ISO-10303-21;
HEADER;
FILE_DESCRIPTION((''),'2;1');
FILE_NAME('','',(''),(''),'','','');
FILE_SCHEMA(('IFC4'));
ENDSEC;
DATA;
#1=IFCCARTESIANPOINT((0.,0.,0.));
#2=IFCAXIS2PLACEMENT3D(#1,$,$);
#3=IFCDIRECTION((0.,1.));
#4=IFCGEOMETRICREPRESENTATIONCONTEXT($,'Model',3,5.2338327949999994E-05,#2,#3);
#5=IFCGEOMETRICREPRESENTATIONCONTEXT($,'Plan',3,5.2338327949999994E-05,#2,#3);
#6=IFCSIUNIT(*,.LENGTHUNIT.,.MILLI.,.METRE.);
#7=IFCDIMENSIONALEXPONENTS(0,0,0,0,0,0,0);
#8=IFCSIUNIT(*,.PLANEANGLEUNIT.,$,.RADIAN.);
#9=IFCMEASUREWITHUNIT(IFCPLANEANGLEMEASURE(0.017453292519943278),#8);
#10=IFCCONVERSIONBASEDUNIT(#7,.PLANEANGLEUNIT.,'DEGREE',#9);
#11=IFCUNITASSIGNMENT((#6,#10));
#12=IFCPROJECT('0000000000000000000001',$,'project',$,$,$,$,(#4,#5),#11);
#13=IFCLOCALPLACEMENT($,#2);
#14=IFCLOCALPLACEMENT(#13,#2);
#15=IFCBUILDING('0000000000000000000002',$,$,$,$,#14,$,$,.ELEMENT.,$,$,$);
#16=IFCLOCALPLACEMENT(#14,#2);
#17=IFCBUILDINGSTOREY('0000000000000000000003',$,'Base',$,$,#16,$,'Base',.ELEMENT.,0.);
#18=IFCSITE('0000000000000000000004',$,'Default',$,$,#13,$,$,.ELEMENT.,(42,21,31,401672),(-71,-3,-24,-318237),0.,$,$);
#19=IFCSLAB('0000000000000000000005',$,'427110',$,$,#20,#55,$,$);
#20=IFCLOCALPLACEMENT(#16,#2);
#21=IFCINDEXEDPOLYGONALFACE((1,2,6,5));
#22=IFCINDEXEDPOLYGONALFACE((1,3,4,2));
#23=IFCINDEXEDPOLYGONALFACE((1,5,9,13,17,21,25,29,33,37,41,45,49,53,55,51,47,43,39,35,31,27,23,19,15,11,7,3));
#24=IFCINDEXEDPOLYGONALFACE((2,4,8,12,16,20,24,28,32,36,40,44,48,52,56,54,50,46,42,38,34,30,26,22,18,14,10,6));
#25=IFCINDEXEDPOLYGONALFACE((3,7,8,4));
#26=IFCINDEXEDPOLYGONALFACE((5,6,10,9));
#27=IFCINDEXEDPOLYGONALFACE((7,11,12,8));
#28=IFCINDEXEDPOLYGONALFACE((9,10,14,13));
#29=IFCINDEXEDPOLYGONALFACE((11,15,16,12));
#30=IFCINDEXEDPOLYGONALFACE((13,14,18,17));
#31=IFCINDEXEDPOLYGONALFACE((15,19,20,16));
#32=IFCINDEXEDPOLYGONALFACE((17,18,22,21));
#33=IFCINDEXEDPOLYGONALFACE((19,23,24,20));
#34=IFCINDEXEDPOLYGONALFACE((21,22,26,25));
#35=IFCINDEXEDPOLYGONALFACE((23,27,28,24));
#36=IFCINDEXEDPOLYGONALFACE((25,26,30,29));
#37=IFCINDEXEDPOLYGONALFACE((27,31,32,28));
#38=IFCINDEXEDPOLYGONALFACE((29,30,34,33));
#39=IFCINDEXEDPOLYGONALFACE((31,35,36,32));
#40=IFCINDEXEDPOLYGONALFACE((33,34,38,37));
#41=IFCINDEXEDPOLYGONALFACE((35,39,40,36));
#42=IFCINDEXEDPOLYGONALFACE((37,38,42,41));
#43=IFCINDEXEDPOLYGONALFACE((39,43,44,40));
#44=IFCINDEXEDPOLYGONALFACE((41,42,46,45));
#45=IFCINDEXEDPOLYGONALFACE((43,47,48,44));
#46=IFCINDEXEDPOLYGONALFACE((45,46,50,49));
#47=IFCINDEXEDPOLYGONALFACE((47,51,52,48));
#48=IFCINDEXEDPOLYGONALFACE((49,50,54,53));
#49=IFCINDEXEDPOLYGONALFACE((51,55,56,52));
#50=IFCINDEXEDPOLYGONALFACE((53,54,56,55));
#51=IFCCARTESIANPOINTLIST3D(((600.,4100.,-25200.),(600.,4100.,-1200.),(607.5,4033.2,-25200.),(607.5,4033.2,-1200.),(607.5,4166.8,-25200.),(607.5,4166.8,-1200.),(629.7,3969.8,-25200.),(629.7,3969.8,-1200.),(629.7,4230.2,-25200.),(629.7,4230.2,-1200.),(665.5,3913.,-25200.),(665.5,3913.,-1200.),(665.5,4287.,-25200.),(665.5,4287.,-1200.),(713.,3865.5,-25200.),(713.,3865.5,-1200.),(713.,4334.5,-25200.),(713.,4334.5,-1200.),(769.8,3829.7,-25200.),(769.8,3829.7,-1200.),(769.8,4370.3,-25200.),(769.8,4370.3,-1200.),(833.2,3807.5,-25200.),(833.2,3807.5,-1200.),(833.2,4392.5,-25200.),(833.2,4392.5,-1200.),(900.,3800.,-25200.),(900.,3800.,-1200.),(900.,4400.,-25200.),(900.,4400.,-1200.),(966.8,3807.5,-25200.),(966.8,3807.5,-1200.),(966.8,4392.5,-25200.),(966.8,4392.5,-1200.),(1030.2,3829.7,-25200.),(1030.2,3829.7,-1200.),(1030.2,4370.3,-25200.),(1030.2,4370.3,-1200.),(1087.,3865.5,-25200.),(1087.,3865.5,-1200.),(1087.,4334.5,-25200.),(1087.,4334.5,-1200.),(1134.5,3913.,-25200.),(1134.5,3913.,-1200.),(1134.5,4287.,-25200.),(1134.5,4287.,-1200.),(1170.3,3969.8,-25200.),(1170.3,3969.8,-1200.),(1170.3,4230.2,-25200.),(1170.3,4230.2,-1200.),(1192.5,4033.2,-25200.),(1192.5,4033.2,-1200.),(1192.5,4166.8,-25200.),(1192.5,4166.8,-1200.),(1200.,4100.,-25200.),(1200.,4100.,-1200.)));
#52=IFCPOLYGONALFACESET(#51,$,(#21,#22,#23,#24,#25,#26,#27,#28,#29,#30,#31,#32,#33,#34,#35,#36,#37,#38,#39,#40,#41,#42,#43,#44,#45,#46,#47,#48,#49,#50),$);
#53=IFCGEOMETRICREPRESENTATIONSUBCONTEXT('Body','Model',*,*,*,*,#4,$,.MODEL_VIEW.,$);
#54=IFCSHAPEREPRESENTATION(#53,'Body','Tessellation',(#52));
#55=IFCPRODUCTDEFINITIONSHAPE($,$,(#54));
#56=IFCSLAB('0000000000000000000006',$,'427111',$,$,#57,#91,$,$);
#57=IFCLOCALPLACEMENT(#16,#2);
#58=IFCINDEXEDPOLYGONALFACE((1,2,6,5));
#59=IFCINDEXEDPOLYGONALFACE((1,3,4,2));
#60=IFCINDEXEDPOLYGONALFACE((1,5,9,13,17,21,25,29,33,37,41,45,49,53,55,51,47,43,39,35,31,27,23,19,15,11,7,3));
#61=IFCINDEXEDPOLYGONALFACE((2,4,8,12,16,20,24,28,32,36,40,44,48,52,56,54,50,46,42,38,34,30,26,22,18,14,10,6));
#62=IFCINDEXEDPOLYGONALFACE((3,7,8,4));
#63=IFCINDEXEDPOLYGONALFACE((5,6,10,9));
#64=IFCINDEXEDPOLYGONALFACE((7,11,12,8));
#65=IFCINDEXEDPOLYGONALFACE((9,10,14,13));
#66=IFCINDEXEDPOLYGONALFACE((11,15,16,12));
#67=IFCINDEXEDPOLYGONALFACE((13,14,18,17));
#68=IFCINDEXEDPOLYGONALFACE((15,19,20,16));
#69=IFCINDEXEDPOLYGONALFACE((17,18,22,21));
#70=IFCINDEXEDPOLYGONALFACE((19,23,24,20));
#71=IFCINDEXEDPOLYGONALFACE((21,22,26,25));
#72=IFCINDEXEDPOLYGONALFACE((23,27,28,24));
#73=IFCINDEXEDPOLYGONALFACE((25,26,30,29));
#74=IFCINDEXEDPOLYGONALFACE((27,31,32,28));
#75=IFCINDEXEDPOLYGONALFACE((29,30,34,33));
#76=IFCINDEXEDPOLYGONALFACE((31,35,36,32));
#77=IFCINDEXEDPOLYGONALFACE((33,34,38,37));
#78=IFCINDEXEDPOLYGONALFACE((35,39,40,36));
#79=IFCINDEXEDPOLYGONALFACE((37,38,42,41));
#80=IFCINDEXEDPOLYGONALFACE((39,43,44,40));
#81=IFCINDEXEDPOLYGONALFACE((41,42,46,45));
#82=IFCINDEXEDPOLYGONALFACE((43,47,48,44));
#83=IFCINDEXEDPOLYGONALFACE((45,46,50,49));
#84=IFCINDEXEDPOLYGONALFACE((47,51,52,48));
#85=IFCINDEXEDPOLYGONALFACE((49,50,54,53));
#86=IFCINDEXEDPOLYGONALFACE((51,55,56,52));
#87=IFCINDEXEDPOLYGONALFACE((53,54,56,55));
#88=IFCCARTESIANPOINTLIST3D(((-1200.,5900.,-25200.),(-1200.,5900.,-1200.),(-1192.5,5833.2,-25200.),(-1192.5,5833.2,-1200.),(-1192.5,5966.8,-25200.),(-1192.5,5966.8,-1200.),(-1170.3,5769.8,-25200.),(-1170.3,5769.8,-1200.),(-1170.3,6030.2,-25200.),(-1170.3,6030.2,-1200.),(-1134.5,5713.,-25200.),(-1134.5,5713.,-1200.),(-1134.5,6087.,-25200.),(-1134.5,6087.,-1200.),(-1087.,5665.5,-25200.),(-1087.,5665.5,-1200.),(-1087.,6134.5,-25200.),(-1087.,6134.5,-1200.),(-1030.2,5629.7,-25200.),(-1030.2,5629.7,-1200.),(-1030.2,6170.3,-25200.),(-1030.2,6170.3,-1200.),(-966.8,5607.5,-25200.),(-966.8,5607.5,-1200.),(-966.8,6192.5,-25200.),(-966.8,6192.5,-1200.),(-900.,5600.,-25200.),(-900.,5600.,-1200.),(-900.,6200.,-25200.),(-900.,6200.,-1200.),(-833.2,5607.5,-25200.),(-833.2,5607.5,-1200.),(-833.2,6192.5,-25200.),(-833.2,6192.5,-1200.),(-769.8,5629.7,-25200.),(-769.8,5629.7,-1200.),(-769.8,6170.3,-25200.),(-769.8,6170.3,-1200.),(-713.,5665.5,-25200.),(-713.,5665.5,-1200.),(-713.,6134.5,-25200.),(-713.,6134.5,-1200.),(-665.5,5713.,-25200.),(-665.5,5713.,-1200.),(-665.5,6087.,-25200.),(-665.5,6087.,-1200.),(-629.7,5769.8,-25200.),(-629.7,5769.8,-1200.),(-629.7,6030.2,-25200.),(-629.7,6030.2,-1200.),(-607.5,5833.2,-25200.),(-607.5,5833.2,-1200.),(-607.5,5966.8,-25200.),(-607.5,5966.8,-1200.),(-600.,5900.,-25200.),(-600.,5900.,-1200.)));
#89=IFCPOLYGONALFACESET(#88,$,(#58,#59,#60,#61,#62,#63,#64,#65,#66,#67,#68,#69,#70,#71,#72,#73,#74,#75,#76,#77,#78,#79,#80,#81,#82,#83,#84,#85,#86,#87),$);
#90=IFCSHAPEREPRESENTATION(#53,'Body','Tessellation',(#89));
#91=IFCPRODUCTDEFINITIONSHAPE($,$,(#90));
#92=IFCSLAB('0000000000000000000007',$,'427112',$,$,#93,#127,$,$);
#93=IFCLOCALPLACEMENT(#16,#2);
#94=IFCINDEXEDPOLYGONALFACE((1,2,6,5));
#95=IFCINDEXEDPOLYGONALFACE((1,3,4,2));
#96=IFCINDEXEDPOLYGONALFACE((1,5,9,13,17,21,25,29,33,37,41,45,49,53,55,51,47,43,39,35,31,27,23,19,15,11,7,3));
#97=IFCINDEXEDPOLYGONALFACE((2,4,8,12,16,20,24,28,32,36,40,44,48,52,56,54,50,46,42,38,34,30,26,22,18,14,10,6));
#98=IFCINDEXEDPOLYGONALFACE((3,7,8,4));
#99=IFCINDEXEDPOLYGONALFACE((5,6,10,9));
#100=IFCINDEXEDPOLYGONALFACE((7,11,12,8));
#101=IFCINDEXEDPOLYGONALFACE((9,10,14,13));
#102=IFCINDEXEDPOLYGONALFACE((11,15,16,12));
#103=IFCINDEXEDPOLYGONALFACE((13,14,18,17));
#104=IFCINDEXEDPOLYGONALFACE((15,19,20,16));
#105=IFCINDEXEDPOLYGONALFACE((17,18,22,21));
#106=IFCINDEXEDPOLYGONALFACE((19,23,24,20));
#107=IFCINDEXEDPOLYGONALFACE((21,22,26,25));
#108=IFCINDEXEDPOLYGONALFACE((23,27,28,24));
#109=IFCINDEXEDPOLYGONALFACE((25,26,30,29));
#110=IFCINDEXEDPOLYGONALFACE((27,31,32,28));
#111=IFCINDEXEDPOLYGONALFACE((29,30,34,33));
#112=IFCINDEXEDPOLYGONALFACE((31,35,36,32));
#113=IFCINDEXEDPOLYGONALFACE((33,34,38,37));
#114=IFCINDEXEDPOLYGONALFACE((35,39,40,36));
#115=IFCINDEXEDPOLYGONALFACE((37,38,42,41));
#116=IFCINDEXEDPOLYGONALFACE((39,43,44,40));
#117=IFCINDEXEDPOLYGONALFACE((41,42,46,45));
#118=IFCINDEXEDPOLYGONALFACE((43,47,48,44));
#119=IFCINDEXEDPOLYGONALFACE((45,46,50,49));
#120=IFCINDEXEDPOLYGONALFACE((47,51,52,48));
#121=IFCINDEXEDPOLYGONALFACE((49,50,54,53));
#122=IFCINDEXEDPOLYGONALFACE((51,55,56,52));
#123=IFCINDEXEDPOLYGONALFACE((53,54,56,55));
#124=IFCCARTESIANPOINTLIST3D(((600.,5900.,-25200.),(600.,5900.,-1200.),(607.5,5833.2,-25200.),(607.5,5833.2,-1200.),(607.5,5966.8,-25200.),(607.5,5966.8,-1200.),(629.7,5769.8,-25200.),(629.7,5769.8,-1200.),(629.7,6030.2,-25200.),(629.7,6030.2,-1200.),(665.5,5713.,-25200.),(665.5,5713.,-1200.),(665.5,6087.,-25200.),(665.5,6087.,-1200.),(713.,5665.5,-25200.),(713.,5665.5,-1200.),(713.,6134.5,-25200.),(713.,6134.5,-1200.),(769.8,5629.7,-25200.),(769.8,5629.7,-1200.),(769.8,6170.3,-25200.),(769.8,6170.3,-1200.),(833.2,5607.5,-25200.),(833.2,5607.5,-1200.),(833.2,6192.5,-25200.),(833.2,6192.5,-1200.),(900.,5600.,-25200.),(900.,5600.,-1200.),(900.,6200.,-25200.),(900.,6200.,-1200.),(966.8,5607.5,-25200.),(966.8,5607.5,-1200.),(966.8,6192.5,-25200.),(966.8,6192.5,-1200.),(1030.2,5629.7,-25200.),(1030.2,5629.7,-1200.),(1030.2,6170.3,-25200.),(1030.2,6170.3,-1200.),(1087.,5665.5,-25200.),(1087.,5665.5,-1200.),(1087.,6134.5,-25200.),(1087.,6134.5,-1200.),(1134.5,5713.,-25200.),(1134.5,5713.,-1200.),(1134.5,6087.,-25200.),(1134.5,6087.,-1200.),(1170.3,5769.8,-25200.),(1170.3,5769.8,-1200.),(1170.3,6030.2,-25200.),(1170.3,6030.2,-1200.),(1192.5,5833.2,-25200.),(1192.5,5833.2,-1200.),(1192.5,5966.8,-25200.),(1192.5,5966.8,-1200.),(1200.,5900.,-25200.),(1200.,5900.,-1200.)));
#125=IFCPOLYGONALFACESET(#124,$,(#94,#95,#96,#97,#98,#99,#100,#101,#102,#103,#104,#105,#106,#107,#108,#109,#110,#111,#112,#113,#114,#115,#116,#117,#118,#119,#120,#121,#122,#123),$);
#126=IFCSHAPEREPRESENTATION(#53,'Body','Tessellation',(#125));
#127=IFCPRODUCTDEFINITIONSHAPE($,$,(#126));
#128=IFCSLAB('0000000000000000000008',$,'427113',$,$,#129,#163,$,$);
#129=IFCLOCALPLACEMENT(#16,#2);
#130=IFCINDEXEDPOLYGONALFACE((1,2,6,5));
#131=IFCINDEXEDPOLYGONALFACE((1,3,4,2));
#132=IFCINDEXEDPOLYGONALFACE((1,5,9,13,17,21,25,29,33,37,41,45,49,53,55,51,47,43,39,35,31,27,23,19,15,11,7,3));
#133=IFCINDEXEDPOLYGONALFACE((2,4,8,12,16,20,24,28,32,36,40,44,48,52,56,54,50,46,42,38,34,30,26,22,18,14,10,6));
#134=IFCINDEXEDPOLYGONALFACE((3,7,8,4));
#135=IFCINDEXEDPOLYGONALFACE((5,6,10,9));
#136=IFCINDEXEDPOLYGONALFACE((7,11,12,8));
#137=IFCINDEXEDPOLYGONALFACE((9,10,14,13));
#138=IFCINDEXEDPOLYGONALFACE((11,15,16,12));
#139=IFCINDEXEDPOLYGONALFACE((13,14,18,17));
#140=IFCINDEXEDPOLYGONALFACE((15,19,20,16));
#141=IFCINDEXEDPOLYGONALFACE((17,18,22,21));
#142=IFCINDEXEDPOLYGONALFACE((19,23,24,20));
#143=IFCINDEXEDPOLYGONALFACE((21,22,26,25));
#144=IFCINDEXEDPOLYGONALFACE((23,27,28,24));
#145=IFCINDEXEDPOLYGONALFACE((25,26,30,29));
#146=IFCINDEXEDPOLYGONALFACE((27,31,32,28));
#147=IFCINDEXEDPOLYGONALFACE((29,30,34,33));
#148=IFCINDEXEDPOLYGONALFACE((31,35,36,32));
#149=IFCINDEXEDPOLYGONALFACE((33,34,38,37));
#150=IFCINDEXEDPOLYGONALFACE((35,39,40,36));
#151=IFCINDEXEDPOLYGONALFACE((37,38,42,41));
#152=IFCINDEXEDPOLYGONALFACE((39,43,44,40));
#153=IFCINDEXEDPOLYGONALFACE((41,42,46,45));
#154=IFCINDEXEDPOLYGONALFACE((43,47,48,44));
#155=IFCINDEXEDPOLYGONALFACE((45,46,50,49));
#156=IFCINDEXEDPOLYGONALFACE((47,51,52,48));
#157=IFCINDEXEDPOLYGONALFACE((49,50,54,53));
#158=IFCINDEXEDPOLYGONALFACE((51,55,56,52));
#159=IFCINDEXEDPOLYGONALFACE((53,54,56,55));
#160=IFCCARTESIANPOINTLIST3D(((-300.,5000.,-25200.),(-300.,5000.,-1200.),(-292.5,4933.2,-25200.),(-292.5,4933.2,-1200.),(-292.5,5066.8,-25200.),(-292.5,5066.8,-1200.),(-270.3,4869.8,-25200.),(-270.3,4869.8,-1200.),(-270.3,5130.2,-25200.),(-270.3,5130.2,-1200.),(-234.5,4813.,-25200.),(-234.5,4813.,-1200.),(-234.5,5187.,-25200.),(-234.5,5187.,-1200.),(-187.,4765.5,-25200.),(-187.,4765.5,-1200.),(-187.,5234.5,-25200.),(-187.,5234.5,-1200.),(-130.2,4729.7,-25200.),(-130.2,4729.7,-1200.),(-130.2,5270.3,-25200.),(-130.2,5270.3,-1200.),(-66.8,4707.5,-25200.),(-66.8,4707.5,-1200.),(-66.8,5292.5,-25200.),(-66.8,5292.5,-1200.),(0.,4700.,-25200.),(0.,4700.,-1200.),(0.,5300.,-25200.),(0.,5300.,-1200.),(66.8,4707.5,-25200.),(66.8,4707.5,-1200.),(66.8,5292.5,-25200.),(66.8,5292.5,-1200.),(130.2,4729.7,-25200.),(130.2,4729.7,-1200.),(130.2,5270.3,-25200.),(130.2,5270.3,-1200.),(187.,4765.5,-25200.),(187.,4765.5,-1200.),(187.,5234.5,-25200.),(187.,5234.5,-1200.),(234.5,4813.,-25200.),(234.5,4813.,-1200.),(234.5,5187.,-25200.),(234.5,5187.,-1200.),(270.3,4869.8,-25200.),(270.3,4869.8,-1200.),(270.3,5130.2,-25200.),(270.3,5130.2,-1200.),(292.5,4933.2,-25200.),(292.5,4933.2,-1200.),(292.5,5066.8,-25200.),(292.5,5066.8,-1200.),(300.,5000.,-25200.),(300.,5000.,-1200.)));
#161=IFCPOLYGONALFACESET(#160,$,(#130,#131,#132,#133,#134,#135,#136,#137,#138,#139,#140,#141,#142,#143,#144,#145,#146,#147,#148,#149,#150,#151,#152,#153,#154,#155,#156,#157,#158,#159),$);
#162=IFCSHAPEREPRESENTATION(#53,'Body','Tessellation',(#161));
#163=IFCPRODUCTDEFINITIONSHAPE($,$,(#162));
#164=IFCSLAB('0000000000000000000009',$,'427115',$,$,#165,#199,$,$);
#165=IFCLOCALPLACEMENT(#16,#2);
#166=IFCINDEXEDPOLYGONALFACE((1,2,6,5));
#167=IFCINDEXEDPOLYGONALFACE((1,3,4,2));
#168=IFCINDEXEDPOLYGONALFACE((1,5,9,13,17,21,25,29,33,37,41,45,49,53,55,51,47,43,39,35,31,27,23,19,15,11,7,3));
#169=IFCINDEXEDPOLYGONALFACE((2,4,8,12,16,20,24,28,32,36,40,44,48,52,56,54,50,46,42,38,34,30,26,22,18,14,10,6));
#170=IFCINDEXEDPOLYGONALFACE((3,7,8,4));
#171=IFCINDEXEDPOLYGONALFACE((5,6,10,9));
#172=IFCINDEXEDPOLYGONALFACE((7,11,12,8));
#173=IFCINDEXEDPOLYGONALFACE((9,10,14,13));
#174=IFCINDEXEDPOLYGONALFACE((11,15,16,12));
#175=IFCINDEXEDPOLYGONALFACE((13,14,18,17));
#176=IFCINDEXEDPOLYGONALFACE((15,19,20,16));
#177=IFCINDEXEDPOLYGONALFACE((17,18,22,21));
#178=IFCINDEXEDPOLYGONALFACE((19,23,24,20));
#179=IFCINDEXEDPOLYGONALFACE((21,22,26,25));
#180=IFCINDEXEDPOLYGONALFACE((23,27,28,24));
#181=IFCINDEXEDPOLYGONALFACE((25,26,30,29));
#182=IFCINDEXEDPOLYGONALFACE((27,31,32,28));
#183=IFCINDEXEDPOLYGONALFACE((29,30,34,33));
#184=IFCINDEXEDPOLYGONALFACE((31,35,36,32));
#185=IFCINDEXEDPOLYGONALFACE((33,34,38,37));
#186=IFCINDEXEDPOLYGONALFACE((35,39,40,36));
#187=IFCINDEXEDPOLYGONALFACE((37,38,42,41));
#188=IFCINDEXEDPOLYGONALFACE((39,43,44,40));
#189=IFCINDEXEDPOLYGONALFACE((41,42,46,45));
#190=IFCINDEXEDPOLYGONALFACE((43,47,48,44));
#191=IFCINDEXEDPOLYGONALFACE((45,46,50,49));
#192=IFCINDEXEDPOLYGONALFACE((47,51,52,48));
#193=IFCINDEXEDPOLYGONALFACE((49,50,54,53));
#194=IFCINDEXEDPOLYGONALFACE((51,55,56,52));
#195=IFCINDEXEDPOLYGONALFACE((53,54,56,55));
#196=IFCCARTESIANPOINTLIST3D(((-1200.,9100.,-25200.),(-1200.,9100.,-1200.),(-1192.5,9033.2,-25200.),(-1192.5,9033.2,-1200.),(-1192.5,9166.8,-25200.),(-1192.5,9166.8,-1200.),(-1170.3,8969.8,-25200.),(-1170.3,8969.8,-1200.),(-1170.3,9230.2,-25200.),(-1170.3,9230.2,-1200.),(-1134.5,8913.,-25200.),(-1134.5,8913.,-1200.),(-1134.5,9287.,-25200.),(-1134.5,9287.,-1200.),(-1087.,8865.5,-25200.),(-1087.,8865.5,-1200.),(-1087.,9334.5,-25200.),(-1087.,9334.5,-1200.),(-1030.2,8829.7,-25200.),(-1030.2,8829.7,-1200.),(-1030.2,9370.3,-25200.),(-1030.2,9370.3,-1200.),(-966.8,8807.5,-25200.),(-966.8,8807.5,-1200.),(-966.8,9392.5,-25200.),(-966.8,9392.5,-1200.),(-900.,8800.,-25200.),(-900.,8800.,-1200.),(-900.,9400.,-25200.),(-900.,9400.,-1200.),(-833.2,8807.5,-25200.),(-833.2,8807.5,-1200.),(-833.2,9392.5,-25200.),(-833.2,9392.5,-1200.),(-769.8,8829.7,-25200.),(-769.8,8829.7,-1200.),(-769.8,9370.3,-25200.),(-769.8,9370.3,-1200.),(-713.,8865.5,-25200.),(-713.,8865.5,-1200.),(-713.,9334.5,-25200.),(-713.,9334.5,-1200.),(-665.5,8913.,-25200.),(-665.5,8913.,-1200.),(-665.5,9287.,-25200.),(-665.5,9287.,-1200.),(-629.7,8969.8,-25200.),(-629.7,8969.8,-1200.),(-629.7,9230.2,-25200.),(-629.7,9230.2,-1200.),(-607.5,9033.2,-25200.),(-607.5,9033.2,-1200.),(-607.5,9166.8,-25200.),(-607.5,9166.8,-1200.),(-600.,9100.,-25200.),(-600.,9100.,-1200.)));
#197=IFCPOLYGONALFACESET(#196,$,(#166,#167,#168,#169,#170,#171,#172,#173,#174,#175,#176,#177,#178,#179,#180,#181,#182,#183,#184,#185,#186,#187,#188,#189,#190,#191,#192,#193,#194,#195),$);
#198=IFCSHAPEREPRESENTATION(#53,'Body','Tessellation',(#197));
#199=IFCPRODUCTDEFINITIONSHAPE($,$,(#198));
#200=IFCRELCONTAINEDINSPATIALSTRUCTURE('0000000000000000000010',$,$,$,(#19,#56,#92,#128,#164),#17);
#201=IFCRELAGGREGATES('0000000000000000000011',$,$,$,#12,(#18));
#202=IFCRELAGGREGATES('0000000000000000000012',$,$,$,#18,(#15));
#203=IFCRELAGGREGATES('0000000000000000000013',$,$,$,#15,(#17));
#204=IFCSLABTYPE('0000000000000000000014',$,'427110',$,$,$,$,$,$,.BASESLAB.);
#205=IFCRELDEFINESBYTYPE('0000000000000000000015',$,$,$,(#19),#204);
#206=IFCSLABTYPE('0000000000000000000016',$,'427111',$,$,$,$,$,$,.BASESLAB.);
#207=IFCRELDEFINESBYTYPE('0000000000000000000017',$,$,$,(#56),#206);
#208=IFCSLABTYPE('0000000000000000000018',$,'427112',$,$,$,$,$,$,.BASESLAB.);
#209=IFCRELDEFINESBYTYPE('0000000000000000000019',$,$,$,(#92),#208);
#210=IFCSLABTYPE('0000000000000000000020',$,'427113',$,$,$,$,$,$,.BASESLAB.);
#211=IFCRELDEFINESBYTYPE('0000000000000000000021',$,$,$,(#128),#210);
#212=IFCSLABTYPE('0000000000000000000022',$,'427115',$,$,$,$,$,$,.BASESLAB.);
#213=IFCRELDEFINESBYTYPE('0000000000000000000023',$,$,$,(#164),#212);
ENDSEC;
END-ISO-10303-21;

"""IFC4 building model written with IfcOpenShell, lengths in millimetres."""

from ifc_helpers import new_model, entity, si_unit, converted_unit, direction, frame, origin, place, context, subcontext, project, spatial, arc, indexed_curve, outline, extrude, type_object, element, save


model = new_model("IFC4")

# Units and contexts
model_context = context("Model", 3, precision=5.2338327949999994e-05, world=origin(), true_north=direction((0.0, 1.0)))
plan_context = context("Plan", 3, precision=5.2338327949999994e-05, world=origin(), true_north=direction((0.0, 1.0)))
body_context = subcontext(model_context, "Body", "Model", "MODEL_VIEW")
ifc_project = project(units=[si_unit("LENGTHUNIT", "METRE", prefix="MILLI"), converted_unit("PLANEANGLEUNIT", "DEGREE", entity("IfcPlaneAngleMeasure", 0.017453292519943278), si_unit("PLANEANGLEUNIT", "RADIAN"), dimensions=[0, 0, 0, 0, 0, 0, 0])], contexts=[model_context, plan_context])

# Site, building, storey
site_placement = place(None, origin())
site = spatial("IfcSite", under=ifc_project, at=site_placement, Name="Default", CompositionType="ELEMENT", RefLatitude=(42, 21, 31, 401672), RefLongitude=(-71, -3, -24, -318237), RefElevation=0.0)
building_placement = place(site_placement, origin())
building = spatial("IfcBuilding", under=site, at=building_placement, CompositionType="ELEMENT")
storey_placement = place(building_placement, origin())
storey = spatial("IfcBuildingStorey", under=building, at=storey_placement, Name="Base", LongName="Base", CompositionType="ELEMENT", Elevation=0.0)

# Slabs
slab_type_1 = type_object("IfcSlabType", Name="427110", PredefinedType="BASESLAB")
slab_1_placement = place(storey_placement, origin())
element("IfcSlab", 1, at=slab_1_placement, inside=storey, type_object=slab_type_1, Name="427110", context=body_context, shape_type="SweptSolid", body=[
    extrude(outline(indexed_curve([(300.0, 0.0), (0.0, 300.0), (-300.0, 0.0), (0.0, -300.0)], segments=[arc(1, 2, 3), arc(3, 4, 1)], self_intersect=False)), frame((900.0, 4100.0, -25200.0)), (0.0, 0.0, 1.0), 24000.0),
])
slab_type_2 = type_object("IfcSlabType", Name="427111", PredefinedType="BASESLAB")
slab_2_placement = place(storey_placement, origin())
element("IfcSlab", 2, at=slab_2_placement, inside=storey, type_object=slab_type_2, Name="427111", context=body_context, shape_type="SweptSolid", body=[
    extrude(outline(indexed_curve([(300.0, 0.0), (0.0, 300.0), (-300.0, 0.0), (0.0, -300.0)], segments=[arc(1, 2, 3), arc(3, 4, 1)], self_intersect=False)), frame((-900.0, 5900.0, -25200.0)), (0.0, 0.0, 1.0), 24000.0),
])
slab_type_3 = type_object("IfcSlabType", Name="427112", PredefinedType="BASESLAB")
slab_3_placement = place(storey_placement, origin())
element("IfcSlab", 3, at=slab_3_placement, inside=storey, type_object=slab_type_3, Name="427112", context=body_context, shape_type="SweptSolid", body=[
    extrude(outline(indexed_curve([(300.0, 0.0), (0.0, 300.0), (-300.0, 0.0), (0.0, -300.0)], segments=[arc(1, 2, 3), arc(3, 4, 1)], self_intersect=False)), frame((900.0, 5900.0, -25200.0)), (0.0, 0.0, 1.0), 24000.0),
])
slab_type_4 = type_object("IfcSlabType", Name="427113", PredefinedType="BASESLAB")
slab_4_placement = place(storey_placement, origin())
element("IfcSlab", 4, at=slab_4_placement, inside=storey, type_object=slab_type_4, Name="427113", context=body_context, shape_type="SweptSolid", body=[
    extrude(outline(indexed_curve([(300.0, 0.0), (0.0, 300.0), (-300.0, 0.0), (0.0, -300.0)], segments=[arc(1, 2, 3), arc(3, 4, 1)], self_intersect=False)), frame((0.0, 5000.0, -25200.0)), (0.0, 0.0, 1.0), 24000.0),
])
slab_type_5 = type_object("IfcSlabType", Name="427115", PredefinedType="BASESLAB")
slab_5_placement = place(storey_placement, origin())
element("IfcSlab", 5, at=slab_5_placement, inside=storey, type_object=slab_type_5, Name="427115", context=body_context, shape_type="SweptSolid", body=[
    extrude(outline(indexed_curve([(300.0, 0.0), (0.0, 300.0), (-300.0, 0.0), (0.0, -300.0)], segments=[arc(1, 2, 3), arc(3, 4, 1)], self_intersect=False)), frame((-900.0, 9100.0, -25200.0)), (0.0, 0.0, 1.0), 24000.0),
])

save(model, "model.ifc")
